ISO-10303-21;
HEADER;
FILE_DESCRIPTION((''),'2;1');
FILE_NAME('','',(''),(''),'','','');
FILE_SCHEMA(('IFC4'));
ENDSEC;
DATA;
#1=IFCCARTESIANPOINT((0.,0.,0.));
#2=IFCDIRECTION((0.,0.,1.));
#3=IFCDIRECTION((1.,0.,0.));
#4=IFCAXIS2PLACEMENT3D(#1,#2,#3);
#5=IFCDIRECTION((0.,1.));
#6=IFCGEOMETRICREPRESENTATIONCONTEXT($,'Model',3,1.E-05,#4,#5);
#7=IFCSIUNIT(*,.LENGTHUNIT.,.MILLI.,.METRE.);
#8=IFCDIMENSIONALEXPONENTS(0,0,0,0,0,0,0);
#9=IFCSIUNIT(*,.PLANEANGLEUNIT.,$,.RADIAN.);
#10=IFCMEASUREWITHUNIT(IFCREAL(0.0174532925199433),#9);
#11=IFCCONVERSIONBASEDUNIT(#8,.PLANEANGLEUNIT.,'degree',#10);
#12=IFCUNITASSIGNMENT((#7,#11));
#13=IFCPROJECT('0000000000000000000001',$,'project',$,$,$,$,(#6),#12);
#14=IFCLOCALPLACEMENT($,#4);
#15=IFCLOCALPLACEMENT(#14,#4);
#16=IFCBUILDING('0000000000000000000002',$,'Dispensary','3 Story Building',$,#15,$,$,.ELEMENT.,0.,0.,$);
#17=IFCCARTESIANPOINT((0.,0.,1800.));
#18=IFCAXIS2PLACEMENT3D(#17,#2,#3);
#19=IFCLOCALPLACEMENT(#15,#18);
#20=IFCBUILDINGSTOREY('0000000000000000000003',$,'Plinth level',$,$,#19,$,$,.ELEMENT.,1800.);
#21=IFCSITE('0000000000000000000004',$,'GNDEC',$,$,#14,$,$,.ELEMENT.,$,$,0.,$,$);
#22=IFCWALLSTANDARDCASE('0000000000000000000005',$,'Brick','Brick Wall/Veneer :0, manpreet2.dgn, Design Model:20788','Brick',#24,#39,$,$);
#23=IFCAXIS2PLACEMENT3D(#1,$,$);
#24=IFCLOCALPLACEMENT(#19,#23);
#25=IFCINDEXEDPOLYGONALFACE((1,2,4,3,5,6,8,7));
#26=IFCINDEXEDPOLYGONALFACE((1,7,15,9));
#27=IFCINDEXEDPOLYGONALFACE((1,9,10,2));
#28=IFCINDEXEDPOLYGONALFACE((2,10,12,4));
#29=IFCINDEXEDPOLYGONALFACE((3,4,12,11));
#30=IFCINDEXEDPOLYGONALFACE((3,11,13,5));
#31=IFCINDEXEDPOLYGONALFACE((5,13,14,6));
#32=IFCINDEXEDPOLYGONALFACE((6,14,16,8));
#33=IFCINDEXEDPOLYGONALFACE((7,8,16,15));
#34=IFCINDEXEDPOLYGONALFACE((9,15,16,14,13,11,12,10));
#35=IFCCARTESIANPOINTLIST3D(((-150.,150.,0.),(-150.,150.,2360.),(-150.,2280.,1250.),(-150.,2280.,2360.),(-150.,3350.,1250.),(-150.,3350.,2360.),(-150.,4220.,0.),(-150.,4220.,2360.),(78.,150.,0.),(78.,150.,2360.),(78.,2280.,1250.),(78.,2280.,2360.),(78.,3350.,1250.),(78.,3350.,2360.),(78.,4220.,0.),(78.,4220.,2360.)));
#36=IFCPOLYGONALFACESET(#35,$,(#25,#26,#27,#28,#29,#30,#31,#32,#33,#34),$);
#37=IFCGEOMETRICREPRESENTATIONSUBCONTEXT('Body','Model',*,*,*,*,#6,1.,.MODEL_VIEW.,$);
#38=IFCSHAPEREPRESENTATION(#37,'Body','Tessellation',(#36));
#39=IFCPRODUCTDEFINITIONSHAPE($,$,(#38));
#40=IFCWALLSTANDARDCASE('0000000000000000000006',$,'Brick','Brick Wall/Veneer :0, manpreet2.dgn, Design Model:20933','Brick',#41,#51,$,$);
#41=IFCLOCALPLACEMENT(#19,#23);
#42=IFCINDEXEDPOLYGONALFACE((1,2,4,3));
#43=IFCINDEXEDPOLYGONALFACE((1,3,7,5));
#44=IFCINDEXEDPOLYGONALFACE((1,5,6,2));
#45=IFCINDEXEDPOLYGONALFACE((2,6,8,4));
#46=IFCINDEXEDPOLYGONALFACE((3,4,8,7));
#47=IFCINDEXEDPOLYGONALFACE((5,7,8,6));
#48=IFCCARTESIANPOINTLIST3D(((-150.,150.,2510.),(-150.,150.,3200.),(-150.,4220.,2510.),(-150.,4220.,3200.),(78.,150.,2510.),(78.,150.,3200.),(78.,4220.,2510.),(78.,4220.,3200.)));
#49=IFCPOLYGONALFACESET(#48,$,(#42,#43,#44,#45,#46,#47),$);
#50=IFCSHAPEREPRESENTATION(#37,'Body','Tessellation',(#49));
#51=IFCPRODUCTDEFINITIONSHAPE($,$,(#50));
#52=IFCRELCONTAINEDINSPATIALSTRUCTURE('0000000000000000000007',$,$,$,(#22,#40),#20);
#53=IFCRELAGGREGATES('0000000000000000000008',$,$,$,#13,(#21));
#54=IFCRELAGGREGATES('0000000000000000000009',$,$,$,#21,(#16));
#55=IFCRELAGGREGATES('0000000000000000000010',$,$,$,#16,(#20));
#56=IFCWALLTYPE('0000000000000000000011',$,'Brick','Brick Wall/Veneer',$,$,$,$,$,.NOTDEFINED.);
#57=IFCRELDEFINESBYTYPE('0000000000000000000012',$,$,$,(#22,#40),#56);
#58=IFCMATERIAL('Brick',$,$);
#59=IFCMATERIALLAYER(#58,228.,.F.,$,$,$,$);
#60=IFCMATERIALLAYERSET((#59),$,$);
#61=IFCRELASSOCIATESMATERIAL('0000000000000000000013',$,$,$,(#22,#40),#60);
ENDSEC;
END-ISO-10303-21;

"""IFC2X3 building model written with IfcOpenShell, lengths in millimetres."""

from ifc_helpers import new_model, entity, si_unit, converted_unit, direction, frame, frame_2d, origin_with_axes, place, context, subcontext, project, spatial, rectangle, extrude, material, layer, layer_set, layer_usage, type_object, element, save


model = new_model("IFC2X3")

# Units and contexts
model_context = context("Model", 3, precision=1e-05, world=origin_with_axes(), true_north=direction((0.0, 1.0)))
body_context = subcontext(model_context, "Body", "Model", "MODEL_VIEW", scale=1.0)
ifc_project = project(units=[si_unit("LENGTHUNIT", "METRE", prefix="MILLI"), converted_unit("PLANEANGLEUNIT", "degree", entity("IfcReal", 0.0174532925199433), si_unit("PLANEANGLEUNIT", "RADIAN"), dimensions=[0, 0, 0, 0, 0, 0, 0])], contexts=[model_context])

# Site, building, storey
site_placement = place(None, origin_with_axes())
site = spatial("IfcSite", under=ifc_project, at=site_placement, Name="GNDEC", CompositionType="ELEMENT", RefElevation=0.0)
building_placement = place(site_placement, origin_with_axes())
building = spatial("IfcBuilding", under=site, at=building_placement, Name="Dispensary", Description="3 Story Building", CompositionType="ELEMENT", ElevationOfRefHeight=0.0, ElevationOfTerrain=0.0)
storey_placement = place(building_placement, frame((0.0, 0.0, 1800.0), z_axis=(0.0, 0.0, 1.0), x_axis=(1.0, 0.0, 0.0)))
storey = spatial("IfcBuildingStorey", under=building, at=storey_placement, Name="Plinth level", CompositionType="ELEMENT", Elevation=1800.0)

# Shared definitions
ifc_material_1 = material(Name="Brick")
ifc_layer = layer(ifc_material_1, 228.0, ventilated=False)
ifc_layer_set = layer_set([ifc_layer])
ifc_layer_usage = layer_usage(ifc_layer_set, "AXIS2", "POSITIVE", 0.0)
wall_type = type_object("IfcWallType", Name="Brick", Description="Brick Wall/Veneer", PredefinedType="NOTDEFINED")

# Wall, opening
wall_1_placement = place(storey_placement, frame((-150.0, 150.0, 0.0), z_axis=(0.0, 0.0, 1.0), x_axis=(0.0, 1.0, 0.0)))
wall_1 = element("IfcWallStandardCase", 1, at=wall_1_placement, inside=storey, type_object=wall_type, material=ifc_layer_usage, Name="Brick", Description="Brick Wall/Veneer :0, manpreet2.dgn, Design Model:20788", ObjectType="Brick", context=body_context, shape_type="SweptSolid", body=[
    extrude(rectangle(XDim=4070.0, YDim=228.0, at=frame_2d((2035.0, -114.0), x_axis=(-1.0, 0.0))), origin_with_axes(), (0.0, 0.0, 1.0), 2360.0),
])
opening_1_placement = place(wall_1_placement, frame((2130.0, -228.0, 1250.0), z_axis=(0.0, 0.0, 1.0), x_axis=(1.0, 0.0, 0.0)))
element("IfcOpeningElement", 2, at=opening_1_placement, cuts=wall_1, ObjectType="Opening", context=body_context, shape_type="SweptSolid", body=[
    extrude(rectangle(XDim=1110.0, YDim=1070.0, at=frame_2d((-535.0, 555.0), x_axis=(0.0, -1.0))), frame((0.0, 0.0, 0.0), z_axis=(0.0, 1.0, 0.0), x_axis=(-1.0, 0.0, 0.0)), (0.0, 0.0, 1.0), 228.0),
])

# Wall
wall_2_placement = place(storey_placement, frame((-150.0, 150.0, 2510.0), z_axis=(0.0, 0.0, 1.0), x_axis=(0.0, 1.0, 0.0)))
element("IfcWallStandardCase", 3, at=wall_2_placement, inside=storey, type_object=wall_type, material=ifc_layer_usage, Name="Brick", Description="Brick Wall/Veneer :0, manpreet2.dgn, Design Model:20933", ObjectType="Brick", context=body_context, shape_type="SweptSolid", body=[
    extrude(rectangle(XDim=4070.0, YDim=228.0, at=frame_2d((2035.0, -114.0), x_axis=(-1.0, 0.0))), origin_with_axes(), (0.0, 0.0, 1.0), 690.0),
])

save(model, "model.ifc")
